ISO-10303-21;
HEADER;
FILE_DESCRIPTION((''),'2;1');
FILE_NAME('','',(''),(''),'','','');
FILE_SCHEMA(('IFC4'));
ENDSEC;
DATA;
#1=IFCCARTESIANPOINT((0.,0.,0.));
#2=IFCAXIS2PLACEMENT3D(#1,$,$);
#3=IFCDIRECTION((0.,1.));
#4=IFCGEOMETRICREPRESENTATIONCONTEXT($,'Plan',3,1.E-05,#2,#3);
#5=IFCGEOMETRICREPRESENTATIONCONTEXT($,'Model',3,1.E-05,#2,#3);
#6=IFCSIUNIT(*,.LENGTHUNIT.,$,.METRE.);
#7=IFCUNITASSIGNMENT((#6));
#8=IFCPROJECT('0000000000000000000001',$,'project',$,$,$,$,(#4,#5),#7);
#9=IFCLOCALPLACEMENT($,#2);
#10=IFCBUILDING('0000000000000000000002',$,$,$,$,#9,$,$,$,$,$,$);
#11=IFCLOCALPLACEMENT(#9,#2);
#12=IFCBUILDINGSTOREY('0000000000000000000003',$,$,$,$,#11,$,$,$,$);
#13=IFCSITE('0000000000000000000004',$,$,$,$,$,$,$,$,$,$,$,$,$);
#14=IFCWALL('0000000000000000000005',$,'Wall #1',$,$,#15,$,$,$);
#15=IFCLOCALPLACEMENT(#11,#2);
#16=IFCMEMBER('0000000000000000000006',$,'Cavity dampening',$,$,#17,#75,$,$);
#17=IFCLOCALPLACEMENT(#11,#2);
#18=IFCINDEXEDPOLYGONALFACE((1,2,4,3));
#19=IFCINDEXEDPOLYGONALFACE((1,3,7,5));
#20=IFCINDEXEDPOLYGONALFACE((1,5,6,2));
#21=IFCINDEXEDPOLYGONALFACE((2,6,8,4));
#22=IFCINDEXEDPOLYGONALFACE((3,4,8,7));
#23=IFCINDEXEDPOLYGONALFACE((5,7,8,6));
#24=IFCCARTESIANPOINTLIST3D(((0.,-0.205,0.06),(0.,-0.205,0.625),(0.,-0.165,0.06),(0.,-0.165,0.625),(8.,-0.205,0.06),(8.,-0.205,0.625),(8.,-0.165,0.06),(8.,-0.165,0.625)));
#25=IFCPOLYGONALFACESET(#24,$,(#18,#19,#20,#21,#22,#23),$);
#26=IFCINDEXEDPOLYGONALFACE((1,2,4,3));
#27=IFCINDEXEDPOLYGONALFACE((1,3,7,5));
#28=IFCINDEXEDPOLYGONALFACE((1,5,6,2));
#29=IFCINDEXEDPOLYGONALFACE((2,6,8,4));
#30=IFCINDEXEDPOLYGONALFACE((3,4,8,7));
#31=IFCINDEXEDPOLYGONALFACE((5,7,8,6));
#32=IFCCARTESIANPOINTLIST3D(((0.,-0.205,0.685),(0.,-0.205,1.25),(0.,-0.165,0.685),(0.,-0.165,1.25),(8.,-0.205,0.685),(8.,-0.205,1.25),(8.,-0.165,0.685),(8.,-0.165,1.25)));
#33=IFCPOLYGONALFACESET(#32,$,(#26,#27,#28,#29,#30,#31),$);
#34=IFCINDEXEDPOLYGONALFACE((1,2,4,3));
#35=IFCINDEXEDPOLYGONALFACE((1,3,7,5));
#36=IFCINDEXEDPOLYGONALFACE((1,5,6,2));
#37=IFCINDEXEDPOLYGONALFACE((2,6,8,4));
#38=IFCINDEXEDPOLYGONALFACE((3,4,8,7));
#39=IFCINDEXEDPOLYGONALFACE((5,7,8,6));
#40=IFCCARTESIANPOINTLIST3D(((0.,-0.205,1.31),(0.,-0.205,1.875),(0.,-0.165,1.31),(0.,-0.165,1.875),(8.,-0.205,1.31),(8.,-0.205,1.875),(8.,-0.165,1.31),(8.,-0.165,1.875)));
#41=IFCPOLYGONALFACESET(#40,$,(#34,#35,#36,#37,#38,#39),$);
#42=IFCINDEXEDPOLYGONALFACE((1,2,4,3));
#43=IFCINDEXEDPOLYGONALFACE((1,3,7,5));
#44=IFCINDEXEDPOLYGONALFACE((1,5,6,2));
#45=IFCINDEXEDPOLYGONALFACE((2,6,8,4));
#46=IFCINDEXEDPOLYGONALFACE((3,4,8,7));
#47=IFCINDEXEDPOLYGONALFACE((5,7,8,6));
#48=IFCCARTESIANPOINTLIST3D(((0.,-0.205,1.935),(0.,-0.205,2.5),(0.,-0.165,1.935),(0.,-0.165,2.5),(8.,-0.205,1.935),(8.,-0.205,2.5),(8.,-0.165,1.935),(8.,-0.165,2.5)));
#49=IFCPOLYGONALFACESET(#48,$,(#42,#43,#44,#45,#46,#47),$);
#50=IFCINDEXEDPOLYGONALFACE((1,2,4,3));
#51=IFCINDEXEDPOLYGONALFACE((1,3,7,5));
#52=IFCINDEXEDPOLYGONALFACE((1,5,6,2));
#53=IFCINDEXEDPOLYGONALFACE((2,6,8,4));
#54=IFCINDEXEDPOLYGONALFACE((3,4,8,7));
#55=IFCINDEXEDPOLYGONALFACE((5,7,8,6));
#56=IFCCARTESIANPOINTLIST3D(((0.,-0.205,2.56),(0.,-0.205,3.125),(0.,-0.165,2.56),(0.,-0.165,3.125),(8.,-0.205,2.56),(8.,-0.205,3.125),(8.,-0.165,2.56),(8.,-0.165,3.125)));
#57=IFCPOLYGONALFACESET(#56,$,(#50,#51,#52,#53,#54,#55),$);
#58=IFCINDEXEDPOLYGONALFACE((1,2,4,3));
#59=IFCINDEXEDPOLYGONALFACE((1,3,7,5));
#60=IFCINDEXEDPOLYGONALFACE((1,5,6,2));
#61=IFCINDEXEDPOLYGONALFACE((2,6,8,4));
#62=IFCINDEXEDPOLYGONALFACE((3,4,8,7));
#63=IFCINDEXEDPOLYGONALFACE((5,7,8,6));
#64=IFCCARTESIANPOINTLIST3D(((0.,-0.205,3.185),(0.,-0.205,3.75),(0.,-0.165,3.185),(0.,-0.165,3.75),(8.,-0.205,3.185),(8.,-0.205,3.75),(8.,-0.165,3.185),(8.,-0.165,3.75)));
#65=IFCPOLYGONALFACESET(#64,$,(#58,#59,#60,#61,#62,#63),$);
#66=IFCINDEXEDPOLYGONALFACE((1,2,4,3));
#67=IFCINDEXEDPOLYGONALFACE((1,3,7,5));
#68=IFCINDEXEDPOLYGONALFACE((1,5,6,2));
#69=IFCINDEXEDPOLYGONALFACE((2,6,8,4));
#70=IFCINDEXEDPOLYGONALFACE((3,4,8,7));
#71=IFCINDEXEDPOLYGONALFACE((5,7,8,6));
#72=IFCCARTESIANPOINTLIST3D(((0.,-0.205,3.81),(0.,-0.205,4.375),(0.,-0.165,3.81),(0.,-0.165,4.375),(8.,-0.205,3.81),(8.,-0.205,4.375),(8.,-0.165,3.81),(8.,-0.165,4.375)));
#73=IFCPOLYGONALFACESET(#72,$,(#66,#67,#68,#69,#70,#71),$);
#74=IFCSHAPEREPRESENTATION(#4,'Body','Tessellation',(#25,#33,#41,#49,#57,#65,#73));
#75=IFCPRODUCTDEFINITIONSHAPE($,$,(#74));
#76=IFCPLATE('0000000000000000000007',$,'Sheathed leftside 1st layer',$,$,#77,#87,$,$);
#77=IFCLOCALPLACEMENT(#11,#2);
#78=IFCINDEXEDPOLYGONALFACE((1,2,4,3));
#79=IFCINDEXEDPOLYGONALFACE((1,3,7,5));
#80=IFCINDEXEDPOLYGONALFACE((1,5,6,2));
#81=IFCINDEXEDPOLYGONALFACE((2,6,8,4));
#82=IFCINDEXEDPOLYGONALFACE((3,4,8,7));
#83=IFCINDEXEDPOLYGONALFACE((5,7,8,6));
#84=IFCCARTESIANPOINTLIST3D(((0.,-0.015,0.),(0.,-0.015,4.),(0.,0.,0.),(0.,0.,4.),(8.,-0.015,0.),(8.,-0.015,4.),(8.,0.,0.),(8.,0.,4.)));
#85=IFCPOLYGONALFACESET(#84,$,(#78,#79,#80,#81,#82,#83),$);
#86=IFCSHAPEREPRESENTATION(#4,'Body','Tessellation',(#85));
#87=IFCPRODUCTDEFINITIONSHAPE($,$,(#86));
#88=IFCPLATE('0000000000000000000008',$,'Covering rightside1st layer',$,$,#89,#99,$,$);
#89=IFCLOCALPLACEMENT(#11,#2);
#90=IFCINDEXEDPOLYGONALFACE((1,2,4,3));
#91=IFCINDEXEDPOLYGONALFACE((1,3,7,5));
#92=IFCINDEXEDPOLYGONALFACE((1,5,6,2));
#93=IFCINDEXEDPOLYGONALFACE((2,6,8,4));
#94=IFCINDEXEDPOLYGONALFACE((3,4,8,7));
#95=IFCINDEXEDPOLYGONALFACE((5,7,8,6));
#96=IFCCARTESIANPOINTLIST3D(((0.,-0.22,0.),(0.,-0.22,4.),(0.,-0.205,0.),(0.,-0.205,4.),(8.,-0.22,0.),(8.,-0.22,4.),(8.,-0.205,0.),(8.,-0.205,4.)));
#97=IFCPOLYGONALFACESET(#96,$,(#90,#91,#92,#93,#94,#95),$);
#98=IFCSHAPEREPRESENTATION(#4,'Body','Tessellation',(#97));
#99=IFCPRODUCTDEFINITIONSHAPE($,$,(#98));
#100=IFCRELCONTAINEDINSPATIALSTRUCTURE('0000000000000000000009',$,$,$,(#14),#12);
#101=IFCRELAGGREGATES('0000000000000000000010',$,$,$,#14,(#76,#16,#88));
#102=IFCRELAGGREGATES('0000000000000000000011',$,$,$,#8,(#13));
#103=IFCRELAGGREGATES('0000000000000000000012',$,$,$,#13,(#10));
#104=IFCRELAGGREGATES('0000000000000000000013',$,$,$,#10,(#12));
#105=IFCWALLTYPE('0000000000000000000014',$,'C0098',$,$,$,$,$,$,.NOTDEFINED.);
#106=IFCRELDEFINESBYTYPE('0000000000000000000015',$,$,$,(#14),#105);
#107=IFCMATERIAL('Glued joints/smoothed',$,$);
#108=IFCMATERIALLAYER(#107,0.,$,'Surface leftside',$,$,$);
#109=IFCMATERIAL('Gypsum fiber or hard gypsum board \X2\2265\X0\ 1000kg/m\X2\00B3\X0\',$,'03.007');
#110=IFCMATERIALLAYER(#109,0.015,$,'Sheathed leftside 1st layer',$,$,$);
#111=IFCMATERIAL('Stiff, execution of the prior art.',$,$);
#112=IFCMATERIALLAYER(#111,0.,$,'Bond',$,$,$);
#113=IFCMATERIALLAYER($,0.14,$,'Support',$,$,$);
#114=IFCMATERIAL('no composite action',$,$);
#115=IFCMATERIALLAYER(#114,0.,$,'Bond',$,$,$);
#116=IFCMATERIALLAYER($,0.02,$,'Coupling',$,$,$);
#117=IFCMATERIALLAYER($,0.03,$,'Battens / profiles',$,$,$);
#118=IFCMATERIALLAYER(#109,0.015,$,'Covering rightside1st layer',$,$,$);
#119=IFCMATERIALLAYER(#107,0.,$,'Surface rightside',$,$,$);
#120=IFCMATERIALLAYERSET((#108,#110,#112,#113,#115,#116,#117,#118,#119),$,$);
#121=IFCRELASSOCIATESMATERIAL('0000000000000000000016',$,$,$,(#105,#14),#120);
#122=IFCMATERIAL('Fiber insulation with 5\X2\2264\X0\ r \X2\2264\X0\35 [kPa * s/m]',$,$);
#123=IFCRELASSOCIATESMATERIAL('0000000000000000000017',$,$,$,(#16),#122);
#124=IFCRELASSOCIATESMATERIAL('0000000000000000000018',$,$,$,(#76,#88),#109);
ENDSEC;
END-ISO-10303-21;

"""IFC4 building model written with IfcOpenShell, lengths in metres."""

from ifc_helpers import new_model, si_unit, direction, frame, frame_2d, origin, origin_with_axes, place, context, project, spatial, rectangle, extrude, material, layer, layer_set, type_object, element, aggregate, save


model = new_model("IFC4")

# Units and contexts
plan_context = context("Plan", 3, precision=1e-05, world=origin(), true_north=direction((0.0, 1.0)))
model_context = context("Model", 3, precision=1e-05, world=origin(), true_north=direction((0.0, 1.0)))
ifc_project = project(units=[si_unit("LENGTHUNIT", "METRE")], contexts=[plan_context, model_context])

# Site, building, storey
site = spatial("IfcSite", under=ifc_project)
building_placement = place(None, origin())
building = spatial("IfcBuilding", under=site, at=building_placement)
storey_placement = place(building_placement, origin())
storey = spatial("IfcBuildingStorey", under=building, at=storey_placement)

# Wall, member, plates
ifc_material_1 = material(Name="Glued joints/smoothed")
ifc_layer_1 = layer(ifc_material_1, 0.0, Name="Surface leftside")
ifc_material_2 = material(Name="Gypsum fiber or hard gypsum board ≥ 1000kg/m³", Category="03.007")
ifc_layer_2 = layer(ifc_material_2, 0.015, Name="Sheathed leftside 1st layer")
ifc_material_3 = material(Name="Stiff, execution of the prior art.")
ifc_layer_3 = layer(ifc_material_3, 0.0, Name="Bond")
ifc_layer_4 = layer(None, 0.14, Name="Support")
ifc_material_4 = material(Name="no composite action")
ifc_layer_5 = layer(ifc_material_4, 0.0, Name="Bond")
ifc_layer_6 = layer(None, 0.02, Name="Coupling")
ifc_layer_7 = layer(None, 0.03, Name="Battens / profiles")
ifc_layer_8 = layer(ifc_material_2, 0.015, Name="Covering rightside1st layer")
ifc_layer_9 = layer(ifc_material_1, 0.0, Name="Surface rightside")
ifc_layer_set = layer_set([ifc_layer_1, ifc_layer_2, ifc_layer_3, ifc_layer_4, ifc_layer_5, ifc_layer_6, ifc_layer_7, ifc_layer_8, ifc_layer_9])
wall_type = type_object("IfcWallType", Name="C0098", PredefinedType="NOTDEFINED", material=ifc_layer_set)
wall_placement = place(None, frame((0.0, 0.0, 0.0), z_axis=(0.0, -1.0, 0.0), x_axis=(1.0, 0.0, 0.0)))
wall = element("IfcWall", 1, at=wall_placement, inside=storey, type_object=wall_type, material=ifc_layer_set, Name="Wall #1")
ifc_material_5 = material(Name="Fiber insulation with 5≤ r ≤35 [kPa * s/m]")
member_1_placement = place(wall_placement, origin())
member_1 = element("IfcMember", 2, at=member_1_placement, material=ifc_material_5, Name="Cavity dampening", context=plan_context, shape_type="SweptSolid", body=[
    extrude(rectangle(XDim=0.565, YDim=0.04, at=frame_2d((0.2825, 0.02), x_axis=(1.0, 0.0))), frame((0.0, 0.06, 0.165), z_axis=(1.0, 0.0, 0.0), x_axis=(0.0, 1.0, 0.0)), (0.0, 0.0, 1.0), 8.0),
    extrude(rectangle(XDim=0.565, YDim=0.04, at=frame_2d((0.2825, 0.02), x_axis=(1.0, 0.0))), frame((0.0, 0.685, 0.165), z_axis=(1.0, 0.0, 0.0), x_axis=(0.0, 1.0, 0.0)), (0.0, 0.0, 1.0), 8.0),
    extrude(rectangle(XDim=0.565, YDim=0.04, at=frame_2d((0.2825, 0.02), x_axis=(1.0, 0.0))), frame((0.0, 1.31, 0.165), z_axis=(1.0, 0.0, 0.0), x_axis=(0.0, 1.0, 0.0)), (0.0, 0.0, 1.0), 8.0),
    extrude(rectangle(XDim=0.565, YDim=0.04, at=frame_2d((0.2825, 0.02), x_axis=(1.0, 0.0))), frame((0.0, 1.935, 0.165), z_axis=(1.0, 0.0, 0.0), x_axis=(0.0, 1.0, 0.0)), (0.0, 0.0, 1.0), 8.0),
    extrude(rectangle(XDim=0.565, YDim=0.04, at=frame_2d((0.2825, 0.02), x_axis=(1.0, 0.0))), frame((0.0, 2.56, 0.165), z_axis=(1.0, 0.0, 0.0), x_axis=(0.0, 1.0, 0.0)), (0.0, 0.0, 1.0), 8.0),
    extrude(rectangle(XDim=0.565, YDim=0.04, at=frame_2d((0.2825, 0.02), x_axis=(1.0, 0.0))), frame((0.0, 3.185, 0.165), z_axis=(1.0, 0.0, 0.0), x_axis=(0.0, 1.0, 0.0)), (0.0, 0.0, 1.0), 8.0),
    extrude(rectangle(XDim=0.565, YDim=0.04, at=frame_2d((0.2825, 0.02), x_axis=(1.0, 0.0))), frame((0.0, 3.81, 0.165), z_axis=(1.0, 0.0, 0.0), x_axis=(0.0, 1.0, 0.0)), (0.0, 0.0, 1.0), 8.0),
])
plate_1_placement = place(wall_placement, origin())
plate_1 = element("IfcPlate", 3, at=plate_1_placement, material=ifc_material_2, Name="Sheathed leftside 1st layer", context=plan_context, shape_type="SweptSolid", body=[
    extrude(rectangle(XDim=8.0, YDim=4.0, at=frame_2d((4.0, 2.0), x_axis=(1.0, 0.0))), origin_with_axes(), (0.0, 0.0, 1.0), 0.015),
])
plate_2_placement = place(wall_placement, origin())
plate_2 = element("IfcPlate", 4, at=plate_2_placement, material=ifc_material_2, Name="Covering rightside1st layer", context=plan_context, shape_type="SweptSolid", body=[
    extrude(rectangle(XDim=8.0, YDim=4.0, at=frame_2d((4.0, 2.0), x_axis=(1.0, 0.0))), frame((0.0, 0.0, 0.205), z_axis=(0.0, 0.0, 1.0), x_axis=(1.0, 0.0, 0.0)), (0.0, 0.0, 1.0), 0.015),
])
aggregate(wall, [plate_1, member_1, plate_2])

save(model, "model.ifc")
